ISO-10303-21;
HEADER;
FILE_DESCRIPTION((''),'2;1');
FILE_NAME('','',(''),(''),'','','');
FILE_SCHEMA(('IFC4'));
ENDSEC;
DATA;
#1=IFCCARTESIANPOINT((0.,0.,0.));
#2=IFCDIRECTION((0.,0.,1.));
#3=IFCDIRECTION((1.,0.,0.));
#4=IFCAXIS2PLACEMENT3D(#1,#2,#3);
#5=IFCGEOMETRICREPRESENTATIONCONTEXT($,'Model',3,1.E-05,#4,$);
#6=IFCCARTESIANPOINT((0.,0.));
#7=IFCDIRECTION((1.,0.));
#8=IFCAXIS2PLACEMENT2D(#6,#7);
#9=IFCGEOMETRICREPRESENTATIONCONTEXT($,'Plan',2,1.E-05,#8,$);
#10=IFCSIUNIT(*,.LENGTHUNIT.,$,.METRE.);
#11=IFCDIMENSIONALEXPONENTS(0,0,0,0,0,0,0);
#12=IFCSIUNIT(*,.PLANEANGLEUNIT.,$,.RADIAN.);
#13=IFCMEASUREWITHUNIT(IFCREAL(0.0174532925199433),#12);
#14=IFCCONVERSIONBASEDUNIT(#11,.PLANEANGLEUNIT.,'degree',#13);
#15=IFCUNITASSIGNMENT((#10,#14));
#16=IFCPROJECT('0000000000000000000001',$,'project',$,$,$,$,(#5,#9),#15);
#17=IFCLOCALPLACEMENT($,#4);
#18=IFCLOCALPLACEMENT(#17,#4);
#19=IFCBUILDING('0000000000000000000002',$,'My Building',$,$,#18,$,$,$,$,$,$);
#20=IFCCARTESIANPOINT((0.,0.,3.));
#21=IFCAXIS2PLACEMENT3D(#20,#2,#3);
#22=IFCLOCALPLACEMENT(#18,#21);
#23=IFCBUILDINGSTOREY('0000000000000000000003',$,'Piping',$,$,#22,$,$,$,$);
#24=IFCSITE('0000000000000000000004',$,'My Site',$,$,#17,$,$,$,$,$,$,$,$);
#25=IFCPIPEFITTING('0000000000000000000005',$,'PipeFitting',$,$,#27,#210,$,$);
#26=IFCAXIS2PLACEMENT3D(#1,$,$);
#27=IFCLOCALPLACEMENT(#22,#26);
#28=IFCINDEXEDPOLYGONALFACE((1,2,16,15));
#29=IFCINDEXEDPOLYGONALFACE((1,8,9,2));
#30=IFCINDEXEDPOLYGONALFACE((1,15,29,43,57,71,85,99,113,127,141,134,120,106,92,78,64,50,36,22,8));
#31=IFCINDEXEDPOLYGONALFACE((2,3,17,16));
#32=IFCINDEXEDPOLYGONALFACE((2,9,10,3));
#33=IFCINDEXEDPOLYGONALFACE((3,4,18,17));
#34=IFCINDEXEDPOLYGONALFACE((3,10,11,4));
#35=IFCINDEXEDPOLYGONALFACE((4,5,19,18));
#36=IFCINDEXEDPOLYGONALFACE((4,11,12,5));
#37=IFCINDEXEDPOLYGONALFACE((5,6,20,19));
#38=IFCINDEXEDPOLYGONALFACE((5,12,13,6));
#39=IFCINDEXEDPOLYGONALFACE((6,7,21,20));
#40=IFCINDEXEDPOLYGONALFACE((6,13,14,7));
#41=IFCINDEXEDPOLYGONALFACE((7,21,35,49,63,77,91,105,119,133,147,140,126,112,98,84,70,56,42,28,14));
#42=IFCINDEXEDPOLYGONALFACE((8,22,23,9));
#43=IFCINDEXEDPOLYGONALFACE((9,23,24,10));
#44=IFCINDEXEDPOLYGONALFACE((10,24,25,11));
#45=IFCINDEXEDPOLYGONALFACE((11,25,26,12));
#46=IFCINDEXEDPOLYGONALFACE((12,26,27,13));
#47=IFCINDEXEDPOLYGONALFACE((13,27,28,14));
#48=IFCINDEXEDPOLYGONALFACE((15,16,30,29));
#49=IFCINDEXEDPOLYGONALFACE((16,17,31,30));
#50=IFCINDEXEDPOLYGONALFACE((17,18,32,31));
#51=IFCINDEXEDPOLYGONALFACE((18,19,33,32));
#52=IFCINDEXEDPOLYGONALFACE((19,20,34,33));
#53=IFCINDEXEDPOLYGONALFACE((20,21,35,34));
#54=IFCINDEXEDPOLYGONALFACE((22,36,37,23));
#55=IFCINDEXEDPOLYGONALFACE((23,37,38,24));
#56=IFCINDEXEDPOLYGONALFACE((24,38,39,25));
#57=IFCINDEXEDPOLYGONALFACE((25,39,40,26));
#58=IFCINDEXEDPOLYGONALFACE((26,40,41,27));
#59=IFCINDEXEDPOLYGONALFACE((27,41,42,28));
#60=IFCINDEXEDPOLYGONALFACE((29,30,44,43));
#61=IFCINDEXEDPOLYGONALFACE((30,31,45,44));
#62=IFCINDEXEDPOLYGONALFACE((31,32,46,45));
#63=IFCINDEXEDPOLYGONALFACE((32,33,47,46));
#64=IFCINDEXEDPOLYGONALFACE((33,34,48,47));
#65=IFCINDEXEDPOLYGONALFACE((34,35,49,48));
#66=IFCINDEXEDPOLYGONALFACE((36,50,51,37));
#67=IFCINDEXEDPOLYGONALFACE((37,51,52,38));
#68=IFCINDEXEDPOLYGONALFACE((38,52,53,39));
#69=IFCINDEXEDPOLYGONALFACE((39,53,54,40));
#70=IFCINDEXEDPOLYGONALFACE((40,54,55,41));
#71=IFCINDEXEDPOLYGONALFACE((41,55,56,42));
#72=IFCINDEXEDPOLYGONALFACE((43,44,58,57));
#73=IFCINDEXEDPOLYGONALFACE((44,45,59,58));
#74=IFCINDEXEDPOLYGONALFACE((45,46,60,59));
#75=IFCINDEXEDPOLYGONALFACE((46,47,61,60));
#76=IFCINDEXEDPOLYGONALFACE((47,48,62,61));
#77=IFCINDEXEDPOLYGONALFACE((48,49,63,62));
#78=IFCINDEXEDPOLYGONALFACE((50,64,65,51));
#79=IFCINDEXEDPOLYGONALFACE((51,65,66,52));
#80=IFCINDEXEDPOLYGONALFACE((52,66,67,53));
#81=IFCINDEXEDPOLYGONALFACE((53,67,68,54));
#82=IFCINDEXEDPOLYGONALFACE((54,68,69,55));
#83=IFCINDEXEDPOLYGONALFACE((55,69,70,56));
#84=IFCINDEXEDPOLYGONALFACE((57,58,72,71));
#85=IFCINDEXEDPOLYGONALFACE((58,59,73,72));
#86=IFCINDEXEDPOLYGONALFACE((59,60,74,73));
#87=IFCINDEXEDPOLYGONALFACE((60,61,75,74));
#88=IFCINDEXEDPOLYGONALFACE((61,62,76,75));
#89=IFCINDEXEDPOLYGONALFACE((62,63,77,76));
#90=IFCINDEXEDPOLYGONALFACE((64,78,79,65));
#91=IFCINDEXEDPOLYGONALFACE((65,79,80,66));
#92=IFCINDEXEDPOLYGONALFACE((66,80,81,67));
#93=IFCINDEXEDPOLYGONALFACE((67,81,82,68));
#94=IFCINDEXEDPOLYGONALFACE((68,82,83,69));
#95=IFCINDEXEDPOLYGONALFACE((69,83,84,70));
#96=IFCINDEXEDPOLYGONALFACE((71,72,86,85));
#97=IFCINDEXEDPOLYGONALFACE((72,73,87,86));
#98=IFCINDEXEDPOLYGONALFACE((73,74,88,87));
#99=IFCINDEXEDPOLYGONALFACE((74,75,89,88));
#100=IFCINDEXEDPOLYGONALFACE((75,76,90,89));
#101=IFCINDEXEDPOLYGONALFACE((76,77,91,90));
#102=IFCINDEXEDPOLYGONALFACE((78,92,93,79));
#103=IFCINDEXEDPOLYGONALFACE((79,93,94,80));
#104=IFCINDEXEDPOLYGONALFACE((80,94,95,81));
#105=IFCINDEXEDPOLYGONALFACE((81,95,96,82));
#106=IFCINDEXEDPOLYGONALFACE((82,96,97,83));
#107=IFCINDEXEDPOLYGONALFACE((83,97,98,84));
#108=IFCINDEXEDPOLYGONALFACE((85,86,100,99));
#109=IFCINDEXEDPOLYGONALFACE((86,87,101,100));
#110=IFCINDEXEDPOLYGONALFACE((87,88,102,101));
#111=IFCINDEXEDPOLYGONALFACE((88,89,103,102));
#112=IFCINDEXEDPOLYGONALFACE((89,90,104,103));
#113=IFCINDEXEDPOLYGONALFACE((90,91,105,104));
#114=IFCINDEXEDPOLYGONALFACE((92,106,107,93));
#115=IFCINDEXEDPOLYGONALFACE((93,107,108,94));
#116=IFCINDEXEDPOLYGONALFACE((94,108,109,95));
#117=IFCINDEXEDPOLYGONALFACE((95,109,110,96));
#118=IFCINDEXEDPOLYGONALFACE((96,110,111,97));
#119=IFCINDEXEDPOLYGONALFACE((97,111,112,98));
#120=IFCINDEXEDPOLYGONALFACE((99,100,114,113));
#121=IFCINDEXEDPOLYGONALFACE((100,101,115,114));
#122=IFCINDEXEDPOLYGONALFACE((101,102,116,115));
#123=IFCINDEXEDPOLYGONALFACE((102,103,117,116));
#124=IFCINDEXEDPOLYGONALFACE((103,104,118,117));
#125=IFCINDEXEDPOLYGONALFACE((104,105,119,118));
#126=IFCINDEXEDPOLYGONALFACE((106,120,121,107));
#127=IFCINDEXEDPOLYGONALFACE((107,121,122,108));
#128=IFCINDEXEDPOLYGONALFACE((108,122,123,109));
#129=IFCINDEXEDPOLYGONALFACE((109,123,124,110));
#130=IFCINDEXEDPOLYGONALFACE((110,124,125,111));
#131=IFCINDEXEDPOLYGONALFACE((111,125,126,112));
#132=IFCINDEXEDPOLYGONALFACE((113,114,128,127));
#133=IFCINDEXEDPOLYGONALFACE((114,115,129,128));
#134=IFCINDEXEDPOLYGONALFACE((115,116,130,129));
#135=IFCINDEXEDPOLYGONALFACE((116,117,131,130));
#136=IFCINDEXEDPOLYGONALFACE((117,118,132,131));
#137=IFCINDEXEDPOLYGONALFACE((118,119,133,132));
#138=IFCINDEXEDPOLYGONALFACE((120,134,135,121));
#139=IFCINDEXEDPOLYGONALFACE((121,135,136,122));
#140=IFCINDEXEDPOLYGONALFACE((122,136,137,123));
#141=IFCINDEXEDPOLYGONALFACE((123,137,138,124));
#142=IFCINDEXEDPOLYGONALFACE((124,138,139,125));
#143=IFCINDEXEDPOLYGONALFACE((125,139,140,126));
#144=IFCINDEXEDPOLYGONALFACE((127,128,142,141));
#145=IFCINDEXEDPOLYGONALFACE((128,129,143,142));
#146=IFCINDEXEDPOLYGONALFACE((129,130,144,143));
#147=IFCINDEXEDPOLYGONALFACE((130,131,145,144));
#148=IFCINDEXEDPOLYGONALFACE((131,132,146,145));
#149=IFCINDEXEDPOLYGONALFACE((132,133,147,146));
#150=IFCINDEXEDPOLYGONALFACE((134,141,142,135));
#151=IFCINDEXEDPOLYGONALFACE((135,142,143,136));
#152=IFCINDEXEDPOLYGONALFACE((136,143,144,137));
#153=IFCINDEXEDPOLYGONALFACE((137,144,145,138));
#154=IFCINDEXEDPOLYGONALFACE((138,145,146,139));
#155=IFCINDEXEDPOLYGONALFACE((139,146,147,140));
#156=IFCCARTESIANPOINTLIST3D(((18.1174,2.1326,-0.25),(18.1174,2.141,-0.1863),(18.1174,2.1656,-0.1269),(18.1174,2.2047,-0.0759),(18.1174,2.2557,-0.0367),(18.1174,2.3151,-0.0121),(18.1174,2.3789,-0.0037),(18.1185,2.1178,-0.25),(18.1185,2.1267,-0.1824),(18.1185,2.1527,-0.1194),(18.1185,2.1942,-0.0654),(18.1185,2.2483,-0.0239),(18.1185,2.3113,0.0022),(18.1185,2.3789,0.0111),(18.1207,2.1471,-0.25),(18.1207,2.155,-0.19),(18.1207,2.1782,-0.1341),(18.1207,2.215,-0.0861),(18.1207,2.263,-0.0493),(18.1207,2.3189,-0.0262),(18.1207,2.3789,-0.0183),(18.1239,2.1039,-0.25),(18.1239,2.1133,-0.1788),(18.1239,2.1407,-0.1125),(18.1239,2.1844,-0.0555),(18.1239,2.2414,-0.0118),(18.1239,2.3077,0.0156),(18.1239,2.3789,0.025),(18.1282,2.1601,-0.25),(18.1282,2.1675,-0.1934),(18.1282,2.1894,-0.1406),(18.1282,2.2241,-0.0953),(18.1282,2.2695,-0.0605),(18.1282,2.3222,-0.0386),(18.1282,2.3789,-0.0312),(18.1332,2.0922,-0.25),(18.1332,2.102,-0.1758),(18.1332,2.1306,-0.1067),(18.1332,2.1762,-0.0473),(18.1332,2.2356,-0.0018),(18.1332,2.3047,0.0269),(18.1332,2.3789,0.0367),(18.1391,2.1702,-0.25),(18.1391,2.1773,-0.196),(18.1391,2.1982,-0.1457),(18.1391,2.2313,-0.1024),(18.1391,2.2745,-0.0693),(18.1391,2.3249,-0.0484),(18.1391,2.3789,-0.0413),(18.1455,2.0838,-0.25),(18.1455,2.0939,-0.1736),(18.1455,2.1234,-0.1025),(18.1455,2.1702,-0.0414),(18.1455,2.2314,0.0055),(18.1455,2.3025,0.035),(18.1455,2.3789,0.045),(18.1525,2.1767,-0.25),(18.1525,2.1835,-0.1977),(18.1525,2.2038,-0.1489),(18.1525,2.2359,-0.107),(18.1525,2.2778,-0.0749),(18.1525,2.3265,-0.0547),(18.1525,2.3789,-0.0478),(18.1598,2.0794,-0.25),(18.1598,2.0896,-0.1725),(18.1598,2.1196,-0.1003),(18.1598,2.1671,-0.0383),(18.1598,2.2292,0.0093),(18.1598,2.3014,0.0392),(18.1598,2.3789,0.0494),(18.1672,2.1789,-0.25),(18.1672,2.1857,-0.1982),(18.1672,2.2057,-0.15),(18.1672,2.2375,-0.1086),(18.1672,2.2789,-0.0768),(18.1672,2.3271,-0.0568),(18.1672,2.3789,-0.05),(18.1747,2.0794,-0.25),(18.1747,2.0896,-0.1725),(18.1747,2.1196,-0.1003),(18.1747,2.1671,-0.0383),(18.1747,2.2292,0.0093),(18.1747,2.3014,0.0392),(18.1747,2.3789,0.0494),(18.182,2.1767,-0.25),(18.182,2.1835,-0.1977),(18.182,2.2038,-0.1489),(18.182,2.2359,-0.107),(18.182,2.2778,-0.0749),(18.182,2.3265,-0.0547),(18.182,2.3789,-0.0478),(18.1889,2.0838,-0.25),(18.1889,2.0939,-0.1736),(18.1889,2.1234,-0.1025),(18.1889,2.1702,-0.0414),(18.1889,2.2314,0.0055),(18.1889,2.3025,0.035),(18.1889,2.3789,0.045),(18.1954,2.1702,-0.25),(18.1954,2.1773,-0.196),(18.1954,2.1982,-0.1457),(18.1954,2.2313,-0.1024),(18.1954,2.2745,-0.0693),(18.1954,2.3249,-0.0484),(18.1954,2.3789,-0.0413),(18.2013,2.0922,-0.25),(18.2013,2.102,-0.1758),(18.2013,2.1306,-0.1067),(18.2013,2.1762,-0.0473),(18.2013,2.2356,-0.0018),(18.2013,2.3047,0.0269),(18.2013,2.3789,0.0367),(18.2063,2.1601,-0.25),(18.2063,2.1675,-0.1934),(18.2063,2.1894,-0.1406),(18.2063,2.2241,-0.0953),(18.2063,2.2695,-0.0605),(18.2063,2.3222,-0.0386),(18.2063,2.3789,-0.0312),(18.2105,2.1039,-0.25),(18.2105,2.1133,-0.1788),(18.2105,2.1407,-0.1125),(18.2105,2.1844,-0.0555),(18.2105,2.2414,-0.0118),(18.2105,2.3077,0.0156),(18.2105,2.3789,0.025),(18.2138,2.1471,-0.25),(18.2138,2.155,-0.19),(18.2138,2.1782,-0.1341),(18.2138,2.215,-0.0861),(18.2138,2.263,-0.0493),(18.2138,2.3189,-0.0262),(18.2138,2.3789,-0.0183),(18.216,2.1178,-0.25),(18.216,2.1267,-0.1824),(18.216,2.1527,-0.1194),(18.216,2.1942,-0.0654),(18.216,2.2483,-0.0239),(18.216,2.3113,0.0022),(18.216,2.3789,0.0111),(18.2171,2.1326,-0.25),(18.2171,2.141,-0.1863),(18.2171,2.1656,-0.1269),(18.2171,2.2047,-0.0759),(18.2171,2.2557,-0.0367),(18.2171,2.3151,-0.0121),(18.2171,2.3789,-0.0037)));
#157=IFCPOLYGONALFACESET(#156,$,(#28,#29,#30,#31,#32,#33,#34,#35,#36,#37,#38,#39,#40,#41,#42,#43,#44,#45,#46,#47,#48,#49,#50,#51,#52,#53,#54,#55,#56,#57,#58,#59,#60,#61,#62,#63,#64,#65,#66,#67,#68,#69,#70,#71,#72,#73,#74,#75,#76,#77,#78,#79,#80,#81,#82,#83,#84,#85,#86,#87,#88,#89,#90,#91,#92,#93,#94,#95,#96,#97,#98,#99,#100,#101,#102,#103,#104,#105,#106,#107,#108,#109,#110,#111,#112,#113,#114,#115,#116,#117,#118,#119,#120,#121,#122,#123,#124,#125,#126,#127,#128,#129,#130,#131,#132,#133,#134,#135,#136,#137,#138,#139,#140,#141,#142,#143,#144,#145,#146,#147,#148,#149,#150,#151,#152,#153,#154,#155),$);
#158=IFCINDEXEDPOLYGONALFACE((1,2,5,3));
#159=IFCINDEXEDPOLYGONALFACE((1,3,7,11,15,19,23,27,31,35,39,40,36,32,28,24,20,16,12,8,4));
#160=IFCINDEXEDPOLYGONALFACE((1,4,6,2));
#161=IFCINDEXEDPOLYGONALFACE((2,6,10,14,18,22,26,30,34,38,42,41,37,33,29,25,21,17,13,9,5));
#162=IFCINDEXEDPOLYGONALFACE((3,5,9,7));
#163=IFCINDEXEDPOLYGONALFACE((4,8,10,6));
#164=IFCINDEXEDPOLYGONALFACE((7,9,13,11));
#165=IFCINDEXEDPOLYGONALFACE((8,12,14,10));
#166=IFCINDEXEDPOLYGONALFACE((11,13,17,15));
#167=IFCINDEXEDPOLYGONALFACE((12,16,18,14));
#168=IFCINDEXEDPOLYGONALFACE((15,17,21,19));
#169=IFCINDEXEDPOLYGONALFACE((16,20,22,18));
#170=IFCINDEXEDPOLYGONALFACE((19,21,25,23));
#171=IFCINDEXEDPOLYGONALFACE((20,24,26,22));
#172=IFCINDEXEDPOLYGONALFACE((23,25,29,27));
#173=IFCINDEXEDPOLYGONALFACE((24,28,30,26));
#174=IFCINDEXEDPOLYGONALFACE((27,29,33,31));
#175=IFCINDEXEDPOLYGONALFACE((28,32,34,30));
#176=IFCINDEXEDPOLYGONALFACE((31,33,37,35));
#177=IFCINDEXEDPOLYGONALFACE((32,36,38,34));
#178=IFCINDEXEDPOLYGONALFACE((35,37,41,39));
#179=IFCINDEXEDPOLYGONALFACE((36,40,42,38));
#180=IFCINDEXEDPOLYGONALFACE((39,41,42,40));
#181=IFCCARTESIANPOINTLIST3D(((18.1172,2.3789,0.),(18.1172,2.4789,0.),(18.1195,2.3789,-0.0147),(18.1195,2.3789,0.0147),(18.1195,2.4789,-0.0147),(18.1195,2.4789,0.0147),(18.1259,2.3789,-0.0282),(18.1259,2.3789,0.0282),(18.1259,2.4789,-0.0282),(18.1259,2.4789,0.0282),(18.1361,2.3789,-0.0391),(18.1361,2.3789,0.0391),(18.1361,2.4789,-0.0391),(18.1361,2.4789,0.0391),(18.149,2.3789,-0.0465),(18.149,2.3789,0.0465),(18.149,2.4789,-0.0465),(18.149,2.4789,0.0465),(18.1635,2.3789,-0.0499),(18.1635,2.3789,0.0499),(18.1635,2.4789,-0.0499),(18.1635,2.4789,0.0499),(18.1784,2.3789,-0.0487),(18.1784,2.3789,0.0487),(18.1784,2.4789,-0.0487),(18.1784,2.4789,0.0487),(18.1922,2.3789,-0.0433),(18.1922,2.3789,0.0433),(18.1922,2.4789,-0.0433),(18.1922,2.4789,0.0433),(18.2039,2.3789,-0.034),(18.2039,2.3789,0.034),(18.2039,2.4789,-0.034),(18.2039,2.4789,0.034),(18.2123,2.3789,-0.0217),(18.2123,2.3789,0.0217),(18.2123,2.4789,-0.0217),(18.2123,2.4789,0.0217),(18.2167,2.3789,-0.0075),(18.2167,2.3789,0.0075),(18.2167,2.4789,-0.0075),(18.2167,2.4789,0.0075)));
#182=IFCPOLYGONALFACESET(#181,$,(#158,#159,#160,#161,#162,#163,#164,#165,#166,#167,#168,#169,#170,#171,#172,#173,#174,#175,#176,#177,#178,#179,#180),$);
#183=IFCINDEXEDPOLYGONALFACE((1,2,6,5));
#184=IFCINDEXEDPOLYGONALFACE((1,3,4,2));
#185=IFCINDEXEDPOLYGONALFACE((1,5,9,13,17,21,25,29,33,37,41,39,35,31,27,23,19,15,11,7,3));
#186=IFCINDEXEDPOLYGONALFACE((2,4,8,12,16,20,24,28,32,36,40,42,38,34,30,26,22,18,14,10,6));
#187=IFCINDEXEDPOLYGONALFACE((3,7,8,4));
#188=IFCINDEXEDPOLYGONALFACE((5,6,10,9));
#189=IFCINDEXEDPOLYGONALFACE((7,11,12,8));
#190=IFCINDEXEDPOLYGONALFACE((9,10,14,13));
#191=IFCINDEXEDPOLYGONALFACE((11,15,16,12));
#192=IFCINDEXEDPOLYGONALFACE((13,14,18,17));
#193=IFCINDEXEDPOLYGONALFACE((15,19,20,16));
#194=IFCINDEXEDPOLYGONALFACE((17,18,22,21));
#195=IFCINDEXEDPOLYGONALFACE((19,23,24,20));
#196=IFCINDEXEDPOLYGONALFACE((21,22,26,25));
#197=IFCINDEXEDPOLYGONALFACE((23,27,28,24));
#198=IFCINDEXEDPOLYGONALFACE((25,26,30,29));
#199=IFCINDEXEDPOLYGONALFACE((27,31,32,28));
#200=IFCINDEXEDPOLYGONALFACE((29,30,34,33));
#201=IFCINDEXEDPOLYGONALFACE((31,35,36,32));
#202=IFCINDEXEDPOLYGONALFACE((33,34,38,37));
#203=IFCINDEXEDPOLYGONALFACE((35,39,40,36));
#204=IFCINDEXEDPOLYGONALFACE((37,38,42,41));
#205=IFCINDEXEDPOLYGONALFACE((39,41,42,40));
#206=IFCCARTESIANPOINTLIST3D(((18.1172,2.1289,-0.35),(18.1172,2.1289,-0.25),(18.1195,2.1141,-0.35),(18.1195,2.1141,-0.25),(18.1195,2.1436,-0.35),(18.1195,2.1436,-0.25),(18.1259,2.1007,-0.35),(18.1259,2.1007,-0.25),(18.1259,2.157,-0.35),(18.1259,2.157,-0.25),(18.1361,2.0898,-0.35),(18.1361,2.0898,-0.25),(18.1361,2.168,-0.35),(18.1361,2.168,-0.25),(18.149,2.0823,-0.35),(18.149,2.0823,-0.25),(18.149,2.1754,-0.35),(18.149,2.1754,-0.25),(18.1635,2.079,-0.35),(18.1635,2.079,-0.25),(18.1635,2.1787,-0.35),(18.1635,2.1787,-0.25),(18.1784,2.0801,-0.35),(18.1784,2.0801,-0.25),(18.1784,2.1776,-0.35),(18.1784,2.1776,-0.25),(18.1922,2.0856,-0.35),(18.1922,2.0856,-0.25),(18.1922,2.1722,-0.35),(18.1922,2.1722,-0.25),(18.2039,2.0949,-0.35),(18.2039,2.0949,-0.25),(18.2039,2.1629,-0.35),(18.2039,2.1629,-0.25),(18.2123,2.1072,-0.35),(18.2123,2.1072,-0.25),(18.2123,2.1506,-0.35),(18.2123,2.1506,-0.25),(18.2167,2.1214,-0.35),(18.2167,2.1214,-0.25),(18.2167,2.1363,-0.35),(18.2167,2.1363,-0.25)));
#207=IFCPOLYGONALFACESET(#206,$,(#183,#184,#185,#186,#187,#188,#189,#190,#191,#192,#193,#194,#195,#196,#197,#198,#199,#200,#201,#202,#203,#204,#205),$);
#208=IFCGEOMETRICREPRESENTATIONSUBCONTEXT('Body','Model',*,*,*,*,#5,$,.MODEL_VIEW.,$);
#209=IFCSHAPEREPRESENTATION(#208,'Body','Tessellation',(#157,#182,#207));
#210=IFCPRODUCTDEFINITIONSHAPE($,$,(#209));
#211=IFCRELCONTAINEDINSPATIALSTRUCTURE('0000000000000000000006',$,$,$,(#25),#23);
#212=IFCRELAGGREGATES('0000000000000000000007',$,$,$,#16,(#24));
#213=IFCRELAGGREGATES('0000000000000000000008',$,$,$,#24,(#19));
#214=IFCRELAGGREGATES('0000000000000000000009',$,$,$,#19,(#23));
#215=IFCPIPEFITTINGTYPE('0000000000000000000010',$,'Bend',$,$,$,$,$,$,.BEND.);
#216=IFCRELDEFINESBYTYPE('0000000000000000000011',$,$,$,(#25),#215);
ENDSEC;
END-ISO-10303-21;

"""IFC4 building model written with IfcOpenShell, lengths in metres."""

from ifc_helpers import new_model, entity, si_unit, converted_unit, frame, origin_with_axes, origin_2d_with_axis, place, context, subcontext, project, spatial, circle, extrude, source, transform, mapped, type_object, type_shapes, element, save


model = new_model("IFC4")

# Units and contexts
model_context = context("Model", 3, precision=1e-05, world=origin_with_axes())
plan_context = context("Plan", 2, precision=1e-05, world=origin_2d_with_axis())
body_context = subcontext(model_context, "Body", "Model", "MODEL_VIEW")
ifc_project = project(units=[si_unit("LENGTHUNIT", "METRE"), converted_unit("PLANEANGLEUNIT", "degree", entity("IfcReal", 0.0174532925199433), si_unit("PLANEANGLEUNIT", "RADIAN"), dimensions=[0, 0, 0, 0, 0, 0, 0])], contexts=[model_context, plan_context])

# Site, building, storey
site_placement = place(None, origin_with_axes())
site = spatial("IfcSite", under=ifc_project, at=site_placement, Name="My Site")
building_placement = place(site_placement, origin_with_axes())
building = spatial("IfcBuilding", under=site, at=building_placement, Name="My Building")
storey_placement = place(building_placement, frame((0.0, 0.0, 3.0), z_axis=(0.0, 0.0, 1.0), x_axis=(1.0, 0.0, 0.0)))
storey = spatial("IfcBuildingStorey", under=building, at=storey_placement, Name="Piping")

# Pipe fitting
pipe_fitting_type = type_object("IfcPipeFittingType", Name="Bend", PredefinedType="BEND")
shared_shape = source(origin_with_axes(), body_context, "Body", "SolidModel", [
    entity("IfcSweptDiskSolid", entity("IfcIndexedPolyCurve", entity("IfcCartesianPointList3D", [[0.0, 0.0, -0.1], [0.0, -0.0732, -0.2768], [0.0, -0.25, -0.35]]), [entity("IfcArcIndex", [1, 2, 3])]), 0.05),
    extrude(circle(Radius=0.05), origin_with_axes(), (0.0, 0.0, -1.0), 0.1),
    extrude(circle(Radius=0.05), frame((0.0, -0.25, -0.35), z_axis=(0.0, -1.0, 0.0), x_axis=(1.0, 0.0, 0.0)), (0.0, 0.0, 1.0), 0.1),
])
type_shapes(pipe_fitting_type, [shared_shape])
for number, where, z_axis, x_axis, name in (
    (1, (18.1672, 2.4789, 0.0), (0.0, 1.0, 0.0), (-1.0, 0.0, 0.0), "PipeFitting"),
):
    element("IfcPipeFitting", number, at=place(storey_placement, frame(where, z_axis=z_axis, x_axis=x_axis)), inside=storey, type_object=pipe_fitting_type, Name=name, context=body_context, shape_type="MappedRepresentation", body=[
        mapped(shared_shape, transform((0.0, 0.0, 0.0), x_axis=(1.0, 0.0, 0.0), y_axis=(0.0, 1.0, 0.0), z_axis=(0.0, 0.0, 1.0), scale=1.0)),
    ])

save(model, "model.ifc")
